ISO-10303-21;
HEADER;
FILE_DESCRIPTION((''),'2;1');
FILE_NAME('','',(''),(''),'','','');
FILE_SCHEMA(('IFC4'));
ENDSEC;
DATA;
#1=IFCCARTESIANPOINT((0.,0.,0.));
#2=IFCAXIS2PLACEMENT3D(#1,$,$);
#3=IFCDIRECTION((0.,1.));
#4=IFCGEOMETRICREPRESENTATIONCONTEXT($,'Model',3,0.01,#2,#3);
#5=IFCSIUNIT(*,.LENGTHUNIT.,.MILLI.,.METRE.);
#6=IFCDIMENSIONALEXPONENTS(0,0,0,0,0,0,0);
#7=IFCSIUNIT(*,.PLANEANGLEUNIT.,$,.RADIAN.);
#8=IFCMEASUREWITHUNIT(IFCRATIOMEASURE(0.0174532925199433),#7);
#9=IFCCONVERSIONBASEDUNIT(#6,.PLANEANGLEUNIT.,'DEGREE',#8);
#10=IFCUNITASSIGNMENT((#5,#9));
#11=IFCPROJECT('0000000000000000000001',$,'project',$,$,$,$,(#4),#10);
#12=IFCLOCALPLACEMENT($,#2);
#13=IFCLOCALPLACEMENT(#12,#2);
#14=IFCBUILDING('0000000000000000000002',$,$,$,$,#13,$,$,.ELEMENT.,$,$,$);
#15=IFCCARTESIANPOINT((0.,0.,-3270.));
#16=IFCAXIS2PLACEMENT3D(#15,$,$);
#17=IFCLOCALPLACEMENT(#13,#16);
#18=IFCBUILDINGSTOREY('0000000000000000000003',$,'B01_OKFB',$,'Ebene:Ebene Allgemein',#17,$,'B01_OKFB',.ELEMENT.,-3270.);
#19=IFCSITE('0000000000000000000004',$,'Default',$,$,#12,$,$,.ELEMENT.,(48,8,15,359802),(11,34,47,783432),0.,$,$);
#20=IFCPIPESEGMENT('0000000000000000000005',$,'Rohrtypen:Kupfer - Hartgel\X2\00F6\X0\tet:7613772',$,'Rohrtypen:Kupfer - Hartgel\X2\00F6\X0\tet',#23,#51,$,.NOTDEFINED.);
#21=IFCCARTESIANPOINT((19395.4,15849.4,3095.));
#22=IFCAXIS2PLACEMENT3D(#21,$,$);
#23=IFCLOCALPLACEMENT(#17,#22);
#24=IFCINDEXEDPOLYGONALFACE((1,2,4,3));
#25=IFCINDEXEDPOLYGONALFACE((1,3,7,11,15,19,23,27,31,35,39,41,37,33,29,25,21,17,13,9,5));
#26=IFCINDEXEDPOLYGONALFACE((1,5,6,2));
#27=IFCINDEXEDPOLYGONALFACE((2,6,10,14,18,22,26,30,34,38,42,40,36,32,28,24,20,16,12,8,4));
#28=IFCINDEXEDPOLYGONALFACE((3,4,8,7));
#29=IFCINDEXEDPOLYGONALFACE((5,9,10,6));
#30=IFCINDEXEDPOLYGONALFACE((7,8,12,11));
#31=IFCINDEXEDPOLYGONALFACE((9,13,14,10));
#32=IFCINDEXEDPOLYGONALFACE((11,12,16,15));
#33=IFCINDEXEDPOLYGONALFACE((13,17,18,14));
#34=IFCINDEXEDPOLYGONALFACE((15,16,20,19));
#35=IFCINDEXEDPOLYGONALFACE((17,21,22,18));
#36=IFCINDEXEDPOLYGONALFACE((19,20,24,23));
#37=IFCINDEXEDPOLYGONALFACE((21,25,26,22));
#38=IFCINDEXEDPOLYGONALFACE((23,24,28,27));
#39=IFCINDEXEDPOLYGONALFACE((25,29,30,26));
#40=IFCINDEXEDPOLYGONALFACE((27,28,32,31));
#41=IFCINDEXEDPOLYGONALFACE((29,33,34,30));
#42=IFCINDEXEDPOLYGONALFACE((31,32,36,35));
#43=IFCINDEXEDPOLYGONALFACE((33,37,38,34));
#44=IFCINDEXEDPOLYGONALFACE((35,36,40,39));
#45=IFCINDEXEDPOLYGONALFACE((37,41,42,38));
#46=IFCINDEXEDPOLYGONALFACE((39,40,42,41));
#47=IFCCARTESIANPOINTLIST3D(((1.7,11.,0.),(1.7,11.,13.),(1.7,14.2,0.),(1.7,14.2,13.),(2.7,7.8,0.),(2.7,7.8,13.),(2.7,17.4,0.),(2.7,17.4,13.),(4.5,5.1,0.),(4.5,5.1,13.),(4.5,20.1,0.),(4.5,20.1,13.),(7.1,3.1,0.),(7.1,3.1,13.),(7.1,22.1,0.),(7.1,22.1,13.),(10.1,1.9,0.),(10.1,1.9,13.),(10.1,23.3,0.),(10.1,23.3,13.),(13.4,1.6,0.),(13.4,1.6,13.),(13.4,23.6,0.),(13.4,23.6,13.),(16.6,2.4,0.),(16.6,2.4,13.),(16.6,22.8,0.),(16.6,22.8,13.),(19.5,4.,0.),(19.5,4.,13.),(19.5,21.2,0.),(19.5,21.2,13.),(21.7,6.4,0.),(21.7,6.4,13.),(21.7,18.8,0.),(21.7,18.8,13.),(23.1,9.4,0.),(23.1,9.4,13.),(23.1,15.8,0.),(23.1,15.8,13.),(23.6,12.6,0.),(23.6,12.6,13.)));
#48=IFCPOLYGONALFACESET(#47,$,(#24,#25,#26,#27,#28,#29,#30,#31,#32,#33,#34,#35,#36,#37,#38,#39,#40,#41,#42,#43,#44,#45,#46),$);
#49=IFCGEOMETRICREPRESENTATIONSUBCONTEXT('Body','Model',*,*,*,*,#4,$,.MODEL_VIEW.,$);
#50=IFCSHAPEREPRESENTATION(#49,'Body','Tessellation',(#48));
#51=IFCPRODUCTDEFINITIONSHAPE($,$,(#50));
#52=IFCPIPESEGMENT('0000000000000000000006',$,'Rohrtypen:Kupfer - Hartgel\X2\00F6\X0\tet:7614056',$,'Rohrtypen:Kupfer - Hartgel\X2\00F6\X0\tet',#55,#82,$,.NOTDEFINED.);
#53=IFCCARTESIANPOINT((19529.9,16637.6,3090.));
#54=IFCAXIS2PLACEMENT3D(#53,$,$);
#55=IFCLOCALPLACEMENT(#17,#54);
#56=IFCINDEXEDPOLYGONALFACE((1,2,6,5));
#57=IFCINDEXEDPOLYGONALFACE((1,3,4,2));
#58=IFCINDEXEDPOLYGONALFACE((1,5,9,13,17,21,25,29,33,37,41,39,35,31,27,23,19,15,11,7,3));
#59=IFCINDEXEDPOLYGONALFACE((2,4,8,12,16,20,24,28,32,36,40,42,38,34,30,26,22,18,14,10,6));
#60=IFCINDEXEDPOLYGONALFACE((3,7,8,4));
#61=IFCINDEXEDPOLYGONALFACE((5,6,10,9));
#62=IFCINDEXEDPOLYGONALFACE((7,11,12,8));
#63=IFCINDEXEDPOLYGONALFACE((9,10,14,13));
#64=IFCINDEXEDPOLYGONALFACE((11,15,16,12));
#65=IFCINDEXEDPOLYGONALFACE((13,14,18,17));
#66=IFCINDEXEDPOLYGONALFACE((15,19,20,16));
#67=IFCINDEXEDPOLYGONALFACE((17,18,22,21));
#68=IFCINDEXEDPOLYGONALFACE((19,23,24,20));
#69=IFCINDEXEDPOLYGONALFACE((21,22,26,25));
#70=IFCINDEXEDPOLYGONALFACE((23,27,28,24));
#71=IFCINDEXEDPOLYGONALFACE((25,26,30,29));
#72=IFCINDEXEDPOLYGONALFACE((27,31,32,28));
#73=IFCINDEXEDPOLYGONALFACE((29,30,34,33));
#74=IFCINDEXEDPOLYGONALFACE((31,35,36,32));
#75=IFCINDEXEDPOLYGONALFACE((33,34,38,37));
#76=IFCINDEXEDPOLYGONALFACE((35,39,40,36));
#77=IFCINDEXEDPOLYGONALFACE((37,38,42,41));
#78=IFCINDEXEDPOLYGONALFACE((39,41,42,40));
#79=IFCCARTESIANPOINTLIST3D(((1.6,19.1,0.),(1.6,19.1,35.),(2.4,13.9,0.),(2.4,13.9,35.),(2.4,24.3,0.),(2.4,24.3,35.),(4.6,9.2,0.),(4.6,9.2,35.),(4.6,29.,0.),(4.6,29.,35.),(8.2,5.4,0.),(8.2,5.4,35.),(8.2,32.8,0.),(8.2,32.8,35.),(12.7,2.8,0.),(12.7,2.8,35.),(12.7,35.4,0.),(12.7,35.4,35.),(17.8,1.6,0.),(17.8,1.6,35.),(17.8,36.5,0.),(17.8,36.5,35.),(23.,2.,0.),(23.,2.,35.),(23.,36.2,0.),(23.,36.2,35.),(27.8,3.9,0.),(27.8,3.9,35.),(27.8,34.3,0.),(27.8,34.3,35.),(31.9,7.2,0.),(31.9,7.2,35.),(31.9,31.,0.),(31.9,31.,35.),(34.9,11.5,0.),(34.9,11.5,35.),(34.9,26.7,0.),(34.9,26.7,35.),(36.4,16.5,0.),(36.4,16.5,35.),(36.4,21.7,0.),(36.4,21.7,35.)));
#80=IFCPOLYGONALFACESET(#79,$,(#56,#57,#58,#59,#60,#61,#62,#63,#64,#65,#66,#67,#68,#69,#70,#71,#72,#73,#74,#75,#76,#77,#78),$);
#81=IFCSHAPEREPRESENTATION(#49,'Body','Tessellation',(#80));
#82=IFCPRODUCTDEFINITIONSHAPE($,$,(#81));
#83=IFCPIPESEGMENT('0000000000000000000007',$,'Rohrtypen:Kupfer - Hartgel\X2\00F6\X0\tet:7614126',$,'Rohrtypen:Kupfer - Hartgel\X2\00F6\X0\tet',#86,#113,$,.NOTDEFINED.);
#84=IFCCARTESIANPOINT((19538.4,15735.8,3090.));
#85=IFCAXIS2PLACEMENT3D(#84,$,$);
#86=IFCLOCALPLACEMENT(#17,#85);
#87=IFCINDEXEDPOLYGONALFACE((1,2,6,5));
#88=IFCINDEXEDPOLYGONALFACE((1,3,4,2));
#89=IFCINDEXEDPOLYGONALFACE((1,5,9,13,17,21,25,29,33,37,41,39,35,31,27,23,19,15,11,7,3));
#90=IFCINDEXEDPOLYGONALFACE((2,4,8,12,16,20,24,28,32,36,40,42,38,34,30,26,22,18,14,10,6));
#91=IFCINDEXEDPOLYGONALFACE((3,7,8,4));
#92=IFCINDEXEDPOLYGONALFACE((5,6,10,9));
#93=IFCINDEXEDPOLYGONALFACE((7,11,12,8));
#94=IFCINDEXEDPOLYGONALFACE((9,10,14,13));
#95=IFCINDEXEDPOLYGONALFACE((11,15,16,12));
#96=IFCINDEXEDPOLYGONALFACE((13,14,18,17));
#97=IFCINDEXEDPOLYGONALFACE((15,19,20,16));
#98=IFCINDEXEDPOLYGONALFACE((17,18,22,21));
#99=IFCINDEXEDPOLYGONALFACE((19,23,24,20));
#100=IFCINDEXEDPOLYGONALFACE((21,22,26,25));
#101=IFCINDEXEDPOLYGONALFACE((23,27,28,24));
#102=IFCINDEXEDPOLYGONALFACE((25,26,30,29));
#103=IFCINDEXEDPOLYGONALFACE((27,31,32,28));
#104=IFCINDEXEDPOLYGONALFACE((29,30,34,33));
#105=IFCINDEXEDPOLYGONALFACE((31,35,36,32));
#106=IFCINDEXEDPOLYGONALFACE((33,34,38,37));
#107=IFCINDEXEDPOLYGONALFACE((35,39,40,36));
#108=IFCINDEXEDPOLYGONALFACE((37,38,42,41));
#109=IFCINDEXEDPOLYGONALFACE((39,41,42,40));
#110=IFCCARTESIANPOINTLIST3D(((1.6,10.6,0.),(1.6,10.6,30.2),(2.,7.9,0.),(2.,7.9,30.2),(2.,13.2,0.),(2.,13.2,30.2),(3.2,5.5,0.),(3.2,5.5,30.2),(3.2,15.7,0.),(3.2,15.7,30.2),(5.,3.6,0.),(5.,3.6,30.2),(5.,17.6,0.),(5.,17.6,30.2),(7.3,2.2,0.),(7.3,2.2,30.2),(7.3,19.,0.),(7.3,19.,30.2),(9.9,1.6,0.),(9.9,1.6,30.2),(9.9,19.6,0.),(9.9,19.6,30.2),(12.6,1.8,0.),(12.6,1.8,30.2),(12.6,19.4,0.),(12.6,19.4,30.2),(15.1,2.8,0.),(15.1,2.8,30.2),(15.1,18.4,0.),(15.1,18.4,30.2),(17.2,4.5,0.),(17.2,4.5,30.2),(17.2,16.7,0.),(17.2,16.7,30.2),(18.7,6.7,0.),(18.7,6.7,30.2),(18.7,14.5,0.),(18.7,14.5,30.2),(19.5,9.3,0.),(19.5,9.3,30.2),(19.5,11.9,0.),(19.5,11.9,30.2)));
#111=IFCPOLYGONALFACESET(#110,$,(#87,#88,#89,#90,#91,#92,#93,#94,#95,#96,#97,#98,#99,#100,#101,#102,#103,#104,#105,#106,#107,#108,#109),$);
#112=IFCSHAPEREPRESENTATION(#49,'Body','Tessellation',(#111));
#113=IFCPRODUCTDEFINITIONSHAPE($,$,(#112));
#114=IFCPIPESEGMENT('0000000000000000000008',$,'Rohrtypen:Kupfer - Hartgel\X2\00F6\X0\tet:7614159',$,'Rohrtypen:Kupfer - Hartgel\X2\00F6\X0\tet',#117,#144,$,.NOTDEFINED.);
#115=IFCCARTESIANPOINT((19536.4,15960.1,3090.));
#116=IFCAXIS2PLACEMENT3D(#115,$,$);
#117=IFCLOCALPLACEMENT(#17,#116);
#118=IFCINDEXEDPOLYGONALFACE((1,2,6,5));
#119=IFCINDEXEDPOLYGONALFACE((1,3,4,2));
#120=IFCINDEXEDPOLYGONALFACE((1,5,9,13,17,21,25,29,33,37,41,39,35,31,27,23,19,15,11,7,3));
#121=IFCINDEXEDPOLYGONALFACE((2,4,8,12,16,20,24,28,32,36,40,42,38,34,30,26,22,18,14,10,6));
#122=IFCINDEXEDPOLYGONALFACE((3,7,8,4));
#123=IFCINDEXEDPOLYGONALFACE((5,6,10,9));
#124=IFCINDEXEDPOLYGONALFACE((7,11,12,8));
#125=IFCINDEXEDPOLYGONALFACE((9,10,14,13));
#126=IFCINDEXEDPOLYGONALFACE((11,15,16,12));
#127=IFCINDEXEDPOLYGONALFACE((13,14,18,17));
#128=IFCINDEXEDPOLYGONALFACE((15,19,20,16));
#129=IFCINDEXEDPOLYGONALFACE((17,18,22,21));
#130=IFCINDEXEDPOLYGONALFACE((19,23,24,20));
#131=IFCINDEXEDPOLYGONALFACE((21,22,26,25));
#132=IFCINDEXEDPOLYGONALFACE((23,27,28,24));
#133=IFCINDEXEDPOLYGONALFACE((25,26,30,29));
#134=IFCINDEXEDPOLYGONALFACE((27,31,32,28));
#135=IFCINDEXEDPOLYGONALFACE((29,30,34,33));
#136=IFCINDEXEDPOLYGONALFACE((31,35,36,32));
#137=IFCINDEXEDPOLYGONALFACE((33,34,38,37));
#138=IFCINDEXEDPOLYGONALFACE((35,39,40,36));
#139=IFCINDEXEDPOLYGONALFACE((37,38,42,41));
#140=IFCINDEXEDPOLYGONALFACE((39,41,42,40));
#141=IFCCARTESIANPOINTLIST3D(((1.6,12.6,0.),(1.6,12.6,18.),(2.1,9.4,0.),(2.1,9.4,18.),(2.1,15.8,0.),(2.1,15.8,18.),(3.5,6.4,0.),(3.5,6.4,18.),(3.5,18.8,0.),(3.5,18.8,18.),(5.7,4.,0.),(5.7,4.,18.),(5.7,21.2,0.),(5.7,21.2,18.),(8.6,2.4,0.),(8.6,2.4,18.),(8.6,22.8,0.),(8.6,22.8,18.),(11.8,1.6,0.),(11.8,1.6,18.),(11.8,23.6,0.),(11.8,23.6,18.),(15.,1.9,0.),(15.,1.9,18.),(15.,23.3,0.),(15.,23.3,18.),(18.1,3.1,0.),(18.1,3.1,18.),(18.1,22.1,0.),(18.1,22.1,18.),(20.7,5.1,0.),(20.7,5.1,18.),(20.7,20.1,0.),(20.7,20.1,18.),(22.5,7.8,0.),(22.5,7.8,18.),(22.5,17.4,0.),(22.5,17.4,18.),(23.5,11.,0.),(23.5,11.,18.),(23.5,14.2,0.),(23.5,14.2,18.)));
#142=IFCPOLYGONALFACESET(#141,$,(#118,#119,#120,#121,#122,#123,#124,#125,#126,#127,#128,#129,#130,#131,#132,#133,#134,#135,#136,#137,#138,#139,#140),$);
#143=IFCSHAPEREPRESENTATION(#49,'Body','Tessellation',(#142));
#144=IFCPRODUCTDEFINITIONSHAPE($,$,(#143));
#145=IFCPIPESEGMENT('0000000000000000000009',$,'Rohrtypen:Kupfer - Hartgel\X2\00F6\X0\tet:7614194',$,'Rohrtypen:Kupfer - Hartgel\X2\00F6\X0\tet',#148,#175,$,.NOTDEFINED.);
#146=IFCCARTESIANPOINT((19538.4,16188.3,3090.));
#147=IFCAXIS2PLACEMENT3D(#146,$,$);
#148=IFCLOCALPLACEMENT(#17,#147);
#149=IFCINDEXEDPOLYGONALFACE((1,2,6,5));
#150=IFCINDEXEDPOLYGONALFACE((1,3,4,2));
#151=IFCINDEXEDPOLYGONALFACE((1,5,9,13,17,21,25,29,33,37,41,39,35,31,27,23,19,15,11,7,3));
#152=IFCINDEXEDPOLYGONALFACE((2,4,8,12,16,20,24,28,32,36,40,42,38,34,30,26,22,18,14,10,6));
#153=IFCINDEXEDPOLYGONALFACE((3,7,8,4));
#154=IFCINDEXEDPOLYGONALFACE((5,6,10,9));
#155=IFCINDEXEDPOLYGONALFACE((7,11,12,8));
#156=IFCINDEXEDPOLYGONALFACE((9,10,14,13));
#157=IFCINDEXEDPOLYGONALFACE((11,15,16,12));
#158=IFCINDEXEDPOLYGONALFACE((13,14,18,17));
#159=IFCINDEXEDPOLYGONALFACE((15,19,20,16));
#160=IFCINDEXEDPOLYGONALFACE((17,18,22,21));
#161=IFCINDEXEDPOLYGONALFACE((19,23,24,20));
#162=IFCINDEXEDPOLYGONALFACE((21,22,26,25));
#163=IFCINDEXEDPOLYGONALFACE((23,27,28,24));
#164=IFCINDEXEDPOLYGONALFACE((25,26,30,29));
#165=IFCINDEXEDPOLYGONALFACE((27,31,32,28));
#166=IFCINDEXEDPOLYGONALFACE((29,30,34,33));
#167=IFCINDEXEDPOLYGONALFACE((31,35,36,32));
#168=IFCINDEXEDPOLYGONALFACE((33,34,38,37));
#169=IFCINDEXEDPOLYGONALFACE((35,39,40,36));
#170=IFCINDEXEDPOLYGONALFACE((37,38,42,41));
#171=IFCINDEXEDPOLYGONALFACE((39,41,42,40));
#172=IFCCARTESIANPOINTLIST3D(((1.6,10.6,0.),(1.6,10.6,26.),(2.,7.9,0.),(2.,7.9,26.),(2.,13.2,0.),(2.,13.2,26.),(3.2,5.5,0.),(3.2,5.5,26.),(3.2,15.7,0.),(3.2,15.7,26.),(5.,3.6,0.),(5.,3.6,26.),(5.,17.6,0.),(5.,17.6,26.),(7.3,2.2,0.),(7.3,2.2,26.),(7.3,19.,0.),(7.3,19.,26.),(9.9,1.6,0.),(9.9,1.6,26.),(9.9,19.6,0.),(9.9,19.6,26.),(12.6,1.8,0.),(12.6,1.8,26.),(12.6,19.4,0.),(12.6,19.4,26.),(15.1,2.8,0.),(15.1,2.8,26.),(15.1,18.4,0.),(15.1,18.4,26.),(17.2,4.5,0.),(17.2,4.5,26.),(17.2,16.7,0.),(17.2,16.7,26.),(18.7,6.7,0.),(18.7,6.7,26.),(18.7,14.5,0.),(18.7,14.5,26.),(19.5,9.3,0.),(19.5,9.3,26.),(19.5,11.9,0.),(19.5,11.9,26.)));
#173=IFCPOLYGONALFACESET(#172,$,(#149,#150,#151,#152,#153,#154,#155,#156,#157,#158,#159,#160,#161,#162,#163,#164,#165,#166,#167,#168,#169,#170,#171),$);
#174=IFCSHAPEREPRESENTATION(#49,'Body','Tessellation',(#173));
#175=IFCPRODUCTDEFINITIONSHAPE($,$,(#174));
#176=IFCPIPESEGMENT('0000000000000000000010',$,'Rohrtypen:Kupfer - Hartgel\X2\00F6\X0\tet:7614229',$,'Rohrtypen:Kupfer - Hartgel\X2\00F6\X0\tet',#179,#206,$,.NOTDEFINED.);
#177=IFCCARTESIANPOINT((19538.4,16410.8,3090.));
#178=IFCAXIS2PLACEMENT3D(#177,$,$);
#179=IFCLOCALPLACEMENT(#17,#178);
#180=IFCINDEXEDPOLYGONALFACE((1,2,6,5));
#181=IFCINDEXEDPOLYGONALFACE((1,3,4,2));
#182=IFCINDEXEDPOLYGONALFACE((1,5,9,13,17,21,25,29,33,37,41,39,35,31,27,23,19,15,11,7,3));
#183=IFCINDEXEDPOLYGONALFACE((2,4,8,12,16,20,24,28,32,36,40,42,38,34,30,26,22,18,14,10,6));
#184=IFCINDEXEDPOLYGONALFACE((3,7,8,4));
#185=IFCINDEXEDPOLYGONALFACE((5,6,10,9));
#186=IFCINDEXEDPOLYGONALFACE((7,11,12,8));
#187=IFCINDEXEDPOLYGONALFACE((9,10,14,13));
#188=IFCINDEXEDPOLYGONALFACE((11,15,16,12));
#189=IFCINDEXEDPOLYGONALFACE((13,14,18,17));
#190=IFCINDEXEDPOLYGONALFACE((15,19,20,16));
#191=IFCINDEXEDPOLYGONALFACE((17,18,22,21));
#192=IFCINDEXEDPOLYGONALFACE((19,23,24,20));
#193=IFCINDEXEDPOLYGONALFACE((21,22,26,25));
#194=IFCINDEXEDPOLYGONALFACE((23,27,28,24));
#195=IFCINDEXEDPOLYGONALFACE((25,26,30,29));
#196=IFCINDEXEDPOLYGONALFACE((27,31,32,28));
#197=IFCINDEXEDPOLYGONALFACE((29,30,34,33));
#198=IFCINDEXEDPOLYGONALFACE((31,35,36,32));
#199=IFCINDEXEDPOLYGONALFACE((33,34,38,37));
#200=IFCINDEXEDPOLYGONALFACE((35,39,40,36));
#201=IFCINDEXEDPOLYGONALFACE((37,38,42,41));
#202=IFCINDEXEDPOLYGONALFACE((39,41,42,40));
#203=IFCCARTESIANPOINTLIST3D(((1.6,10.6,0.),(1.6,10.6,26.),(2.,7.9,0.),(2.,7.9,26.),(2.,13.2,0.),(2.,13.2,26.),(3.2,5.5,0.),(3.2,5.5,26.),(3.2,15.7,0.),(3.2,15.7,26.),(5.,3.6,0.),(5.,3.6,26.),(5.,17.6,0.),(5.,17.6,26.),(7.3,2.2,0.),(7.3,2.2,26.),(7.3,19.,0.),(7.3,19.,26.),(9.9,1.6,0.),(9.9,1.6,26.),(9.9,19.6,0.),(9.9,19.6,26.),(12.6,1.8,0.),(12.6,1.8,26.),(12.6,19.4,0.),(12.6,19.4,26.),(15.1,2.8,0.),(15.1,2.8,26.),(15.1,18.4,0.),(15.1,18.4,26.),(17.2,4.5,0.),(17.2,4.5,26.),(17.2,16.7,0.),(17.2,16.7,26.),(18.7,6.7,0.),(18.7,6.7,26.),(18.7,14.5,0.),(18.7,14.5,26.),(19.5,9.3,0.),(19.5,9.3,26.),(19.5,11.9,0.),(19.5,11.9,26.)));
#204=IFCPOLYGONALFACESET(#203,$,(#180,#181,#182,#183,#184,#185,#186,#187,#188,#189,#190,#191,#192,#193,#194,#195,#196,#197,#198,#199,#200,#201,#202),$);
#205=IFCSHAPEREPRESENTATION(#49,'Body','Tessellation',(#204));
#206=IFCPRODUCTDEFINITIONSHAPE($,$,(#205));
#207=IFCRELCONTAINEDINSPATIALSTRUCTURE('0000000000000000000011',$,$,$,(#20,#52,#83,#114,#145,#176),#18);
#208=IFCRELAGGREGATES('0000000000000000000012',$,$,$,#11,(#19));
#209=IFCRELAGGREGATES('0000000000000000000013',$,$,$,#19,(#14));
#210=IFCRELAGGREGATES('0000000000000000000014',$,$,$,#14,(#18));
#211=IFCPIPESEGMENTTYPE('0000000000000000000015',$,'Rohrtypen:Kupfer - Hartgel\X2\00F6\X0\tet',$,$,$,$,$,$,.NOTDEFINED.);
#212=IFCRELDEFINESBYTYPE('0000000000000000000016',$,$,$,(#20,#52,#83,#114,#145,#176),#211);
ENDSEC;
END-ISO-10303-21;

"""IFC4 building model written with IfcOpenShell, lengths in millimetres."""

from ifc_helpers import new_model, entity, si_unit, converted_unit, direction, frame, frame_2d, origin, origin_2d_with_axis, place, context, subcontext, project, spatial, circle, extrude, type_object, element, save


model = new_model("IFC4")

# Units and contexts
model_context = context("Model", 3, precision=0.01, world=origin(), true_north=direction((0.0, 1.0)))
body_context = subcontext(model_context, "Body", "Model", "MODEL_VIEW")
ifc_project = project(units=[si_unit("LENGTHUNIT", "METRE", prefix="MILLI"), converted_unit("PLANEANGLEUNIT", "DEGREE", entity("IfcRatioMeasure", 0.0174532925199433), si_unit("PLANEANGLEUNIT", "RADIAN"), dimensions=[0, 0, 0, 0, 0, 0, 0])], contexts=[model_context])

# Site, building, storey
site_placement = place(None, origin())
site = spatial("IfcSite", under=ifc_project, at=site_placement, Name="Default", CompositionType="ELEMENT", RefLatitude=(48, 8, 15, 359802), RefLongitude=(11, 34, 47, 783432), RefElevation=0.0)
building_placement = place(site_placement, origin())
building = spatial("IfcBuilding", under=site, at=building_placement, CompositionType="ELEMENT")
storey_placement = place(building_placement, frame((0.0, 0.0, -3270.0)))
storey = spatial("IfcBuildingStorey", under=building, at=storey_placement, Name="B01_OKFB", ObjectType="Ebene:Ebene Allgemein", LongName="B01_OKFB", CompositionType="ELEMENT", Elevation=-3270.0)

# Pipe segments
pipe_segment_type = type_object("IfcPipeSegmentType", Name="Rohrtypen:Kupfer - Hartgelötet", PredefinedType="NOTDEFINED")
pipe_segment_1_placement = place(storey_placement, frame((19395.4, 15849.4, 3095.0)))
element("IfcPipeSegment", 1, at=pipe_segment_1_placement, inside=storey, type_object=pipe_segment_type, Name="Rohrtypen:Kupfer - Hartgelötet:7613772", ObjectType="Rohrtypen:Kupfer - Hartgelötet", PredefinedType="NOTDEFINED", context=body_context, shape_type="SweptSolid", body=[
    extrude(circle(Radius=11.0, at=frame_2d((0.0, 0.0), x_axis=(1.0, 0.0))), frame((12.6, 12.6, 0.0)), (0.0, 0.0, 1.0), 13.0),
])
pipe_segment_2_placement = place(storey_placement, frame((19529.9, 16637.6, 3090.0)))
element("IfcPipeSegment", 2, at=pipe_segment_2_placement, inside=storey, type_object=pipe_segment_type, Name="Rohrtypen:Kupfer - Hartgelötet:7614056", ObjectType="Rohrtypen:Kupfer - Hartgelötet", PredefinedType="NOTDEFINED", context=body_context, shape_type="SweptSolid", body=[
    extrude(circle(Radius=17.5, at=origin_2d_with_axis()), frame((19.1, 19.1, 0.0), z_axis=(0.0, 0.0, 1.0), x_axis=(-1.0, 0.0, 0.0)), (0.0, 0.0, 1.0), 35.0),
])
pipe_segment_3_placement = place(storey_placement, frame((19538.4, 15735.8, 3090.0)))
element("IfcPipeSegment", 3, at=pipe_segment_3_placement, inside=storey, type_object=pipe_segment_type, Name="Rohrtypen:Kupfer - Hartgelötet:7614126", ObjectType="Rohrtypen:Kupfer - Hartgelötet", PredefinedType="NOTDEFINED", context=body_context, shape_type="SweptSolid", body=[
    extrude(circle(Radius=9.0, at=origin_2d_with_axis()), frame((10.6, 10.6, 0.0), z_axis=(0.0, 0.0, 1.0), x_axis=(-1.0, 0.0, 0.0)), (0.0, 0.0, 1.0), 30.2),
])
pipe_segment_4_placement = place(storey_placement, frame((19536.4, 15960.1, 3090.0)))
element("IfcPipeSegment", 4, at=pipe_segment_4_placement, inside=storey, type_object=pipe_segment_type, Name="Rohrtypen:Kupfer - Hartgelötet:7614159", ObjectType="Rohrtypen:Kupfer - Hartgelötet", PredefinedType="NOTDEFINED", context=body_context, shape_type="SweptSolid", body=[
    extrude(circle(Radius=11.0, at=origin_2d_with_axis()), frame((12.6, 12.6, 0.0), z_axis=(0.0, 0.0, 1.0), x_axis=(-1.0, 0.0, 0.0)), (0.0, 0.0, 1.0), 18.0),
])
pipe_segment_5_placement = place(storey_placement, frame((19538.4, 16188.3, 3090.0)))
element("IfcPipeSegment", 5, at=pipe_segment_5_placement, inside=storey, type_object=pipe_segment_type, Name="Rohrtypen:Kupfer - Hartgelötet:7614194", ObjectType="Rohrtypen:Kupfer - Hartgelötet", PredefinedType="NOTDEFINED", context=body_context, shape_type="SweptSolid", body=[
    extrude(circle(Radius=9.0, at=frame_2d((0.0, 0.0), x_axis=(1.0, 0.0))), frame((10.6, 10.6, 0.0), z_axis=(0.0, 0.0, 1.0), x_axis=(-1.0, 0.0, 0.0)), (0.0, 0.0, 1.0), 26.0),
])
pipe_segment_6_placement = place(storey_placement, frame((19538.4, 16410.8, 3090.0)))
element("IfcPipeSegment", 6, at=pipe_segment_6_placement, inside=storey, type_object=pipe_segment_type, Name="Rohrtypen:Kupfer - Hartgelötet:7614229", ObjectType="Rohrtypen:Kupfer - Hartgelötet", PredefinedType="NOTDEFINED", context=body_context, shape_type="SweptSolid", body=[
    extrude(circle(Radius=9.0, at=origin_2d_with_axis()), frame((10.6, 10.6, 0.0), z_axis=(0.0, 0.0, 1.0), x_axis=(-1.0, 0.0, 0.0)), (0.0, 0.0, 1.0), 26.0),
])

save(model, "model.ifc")
